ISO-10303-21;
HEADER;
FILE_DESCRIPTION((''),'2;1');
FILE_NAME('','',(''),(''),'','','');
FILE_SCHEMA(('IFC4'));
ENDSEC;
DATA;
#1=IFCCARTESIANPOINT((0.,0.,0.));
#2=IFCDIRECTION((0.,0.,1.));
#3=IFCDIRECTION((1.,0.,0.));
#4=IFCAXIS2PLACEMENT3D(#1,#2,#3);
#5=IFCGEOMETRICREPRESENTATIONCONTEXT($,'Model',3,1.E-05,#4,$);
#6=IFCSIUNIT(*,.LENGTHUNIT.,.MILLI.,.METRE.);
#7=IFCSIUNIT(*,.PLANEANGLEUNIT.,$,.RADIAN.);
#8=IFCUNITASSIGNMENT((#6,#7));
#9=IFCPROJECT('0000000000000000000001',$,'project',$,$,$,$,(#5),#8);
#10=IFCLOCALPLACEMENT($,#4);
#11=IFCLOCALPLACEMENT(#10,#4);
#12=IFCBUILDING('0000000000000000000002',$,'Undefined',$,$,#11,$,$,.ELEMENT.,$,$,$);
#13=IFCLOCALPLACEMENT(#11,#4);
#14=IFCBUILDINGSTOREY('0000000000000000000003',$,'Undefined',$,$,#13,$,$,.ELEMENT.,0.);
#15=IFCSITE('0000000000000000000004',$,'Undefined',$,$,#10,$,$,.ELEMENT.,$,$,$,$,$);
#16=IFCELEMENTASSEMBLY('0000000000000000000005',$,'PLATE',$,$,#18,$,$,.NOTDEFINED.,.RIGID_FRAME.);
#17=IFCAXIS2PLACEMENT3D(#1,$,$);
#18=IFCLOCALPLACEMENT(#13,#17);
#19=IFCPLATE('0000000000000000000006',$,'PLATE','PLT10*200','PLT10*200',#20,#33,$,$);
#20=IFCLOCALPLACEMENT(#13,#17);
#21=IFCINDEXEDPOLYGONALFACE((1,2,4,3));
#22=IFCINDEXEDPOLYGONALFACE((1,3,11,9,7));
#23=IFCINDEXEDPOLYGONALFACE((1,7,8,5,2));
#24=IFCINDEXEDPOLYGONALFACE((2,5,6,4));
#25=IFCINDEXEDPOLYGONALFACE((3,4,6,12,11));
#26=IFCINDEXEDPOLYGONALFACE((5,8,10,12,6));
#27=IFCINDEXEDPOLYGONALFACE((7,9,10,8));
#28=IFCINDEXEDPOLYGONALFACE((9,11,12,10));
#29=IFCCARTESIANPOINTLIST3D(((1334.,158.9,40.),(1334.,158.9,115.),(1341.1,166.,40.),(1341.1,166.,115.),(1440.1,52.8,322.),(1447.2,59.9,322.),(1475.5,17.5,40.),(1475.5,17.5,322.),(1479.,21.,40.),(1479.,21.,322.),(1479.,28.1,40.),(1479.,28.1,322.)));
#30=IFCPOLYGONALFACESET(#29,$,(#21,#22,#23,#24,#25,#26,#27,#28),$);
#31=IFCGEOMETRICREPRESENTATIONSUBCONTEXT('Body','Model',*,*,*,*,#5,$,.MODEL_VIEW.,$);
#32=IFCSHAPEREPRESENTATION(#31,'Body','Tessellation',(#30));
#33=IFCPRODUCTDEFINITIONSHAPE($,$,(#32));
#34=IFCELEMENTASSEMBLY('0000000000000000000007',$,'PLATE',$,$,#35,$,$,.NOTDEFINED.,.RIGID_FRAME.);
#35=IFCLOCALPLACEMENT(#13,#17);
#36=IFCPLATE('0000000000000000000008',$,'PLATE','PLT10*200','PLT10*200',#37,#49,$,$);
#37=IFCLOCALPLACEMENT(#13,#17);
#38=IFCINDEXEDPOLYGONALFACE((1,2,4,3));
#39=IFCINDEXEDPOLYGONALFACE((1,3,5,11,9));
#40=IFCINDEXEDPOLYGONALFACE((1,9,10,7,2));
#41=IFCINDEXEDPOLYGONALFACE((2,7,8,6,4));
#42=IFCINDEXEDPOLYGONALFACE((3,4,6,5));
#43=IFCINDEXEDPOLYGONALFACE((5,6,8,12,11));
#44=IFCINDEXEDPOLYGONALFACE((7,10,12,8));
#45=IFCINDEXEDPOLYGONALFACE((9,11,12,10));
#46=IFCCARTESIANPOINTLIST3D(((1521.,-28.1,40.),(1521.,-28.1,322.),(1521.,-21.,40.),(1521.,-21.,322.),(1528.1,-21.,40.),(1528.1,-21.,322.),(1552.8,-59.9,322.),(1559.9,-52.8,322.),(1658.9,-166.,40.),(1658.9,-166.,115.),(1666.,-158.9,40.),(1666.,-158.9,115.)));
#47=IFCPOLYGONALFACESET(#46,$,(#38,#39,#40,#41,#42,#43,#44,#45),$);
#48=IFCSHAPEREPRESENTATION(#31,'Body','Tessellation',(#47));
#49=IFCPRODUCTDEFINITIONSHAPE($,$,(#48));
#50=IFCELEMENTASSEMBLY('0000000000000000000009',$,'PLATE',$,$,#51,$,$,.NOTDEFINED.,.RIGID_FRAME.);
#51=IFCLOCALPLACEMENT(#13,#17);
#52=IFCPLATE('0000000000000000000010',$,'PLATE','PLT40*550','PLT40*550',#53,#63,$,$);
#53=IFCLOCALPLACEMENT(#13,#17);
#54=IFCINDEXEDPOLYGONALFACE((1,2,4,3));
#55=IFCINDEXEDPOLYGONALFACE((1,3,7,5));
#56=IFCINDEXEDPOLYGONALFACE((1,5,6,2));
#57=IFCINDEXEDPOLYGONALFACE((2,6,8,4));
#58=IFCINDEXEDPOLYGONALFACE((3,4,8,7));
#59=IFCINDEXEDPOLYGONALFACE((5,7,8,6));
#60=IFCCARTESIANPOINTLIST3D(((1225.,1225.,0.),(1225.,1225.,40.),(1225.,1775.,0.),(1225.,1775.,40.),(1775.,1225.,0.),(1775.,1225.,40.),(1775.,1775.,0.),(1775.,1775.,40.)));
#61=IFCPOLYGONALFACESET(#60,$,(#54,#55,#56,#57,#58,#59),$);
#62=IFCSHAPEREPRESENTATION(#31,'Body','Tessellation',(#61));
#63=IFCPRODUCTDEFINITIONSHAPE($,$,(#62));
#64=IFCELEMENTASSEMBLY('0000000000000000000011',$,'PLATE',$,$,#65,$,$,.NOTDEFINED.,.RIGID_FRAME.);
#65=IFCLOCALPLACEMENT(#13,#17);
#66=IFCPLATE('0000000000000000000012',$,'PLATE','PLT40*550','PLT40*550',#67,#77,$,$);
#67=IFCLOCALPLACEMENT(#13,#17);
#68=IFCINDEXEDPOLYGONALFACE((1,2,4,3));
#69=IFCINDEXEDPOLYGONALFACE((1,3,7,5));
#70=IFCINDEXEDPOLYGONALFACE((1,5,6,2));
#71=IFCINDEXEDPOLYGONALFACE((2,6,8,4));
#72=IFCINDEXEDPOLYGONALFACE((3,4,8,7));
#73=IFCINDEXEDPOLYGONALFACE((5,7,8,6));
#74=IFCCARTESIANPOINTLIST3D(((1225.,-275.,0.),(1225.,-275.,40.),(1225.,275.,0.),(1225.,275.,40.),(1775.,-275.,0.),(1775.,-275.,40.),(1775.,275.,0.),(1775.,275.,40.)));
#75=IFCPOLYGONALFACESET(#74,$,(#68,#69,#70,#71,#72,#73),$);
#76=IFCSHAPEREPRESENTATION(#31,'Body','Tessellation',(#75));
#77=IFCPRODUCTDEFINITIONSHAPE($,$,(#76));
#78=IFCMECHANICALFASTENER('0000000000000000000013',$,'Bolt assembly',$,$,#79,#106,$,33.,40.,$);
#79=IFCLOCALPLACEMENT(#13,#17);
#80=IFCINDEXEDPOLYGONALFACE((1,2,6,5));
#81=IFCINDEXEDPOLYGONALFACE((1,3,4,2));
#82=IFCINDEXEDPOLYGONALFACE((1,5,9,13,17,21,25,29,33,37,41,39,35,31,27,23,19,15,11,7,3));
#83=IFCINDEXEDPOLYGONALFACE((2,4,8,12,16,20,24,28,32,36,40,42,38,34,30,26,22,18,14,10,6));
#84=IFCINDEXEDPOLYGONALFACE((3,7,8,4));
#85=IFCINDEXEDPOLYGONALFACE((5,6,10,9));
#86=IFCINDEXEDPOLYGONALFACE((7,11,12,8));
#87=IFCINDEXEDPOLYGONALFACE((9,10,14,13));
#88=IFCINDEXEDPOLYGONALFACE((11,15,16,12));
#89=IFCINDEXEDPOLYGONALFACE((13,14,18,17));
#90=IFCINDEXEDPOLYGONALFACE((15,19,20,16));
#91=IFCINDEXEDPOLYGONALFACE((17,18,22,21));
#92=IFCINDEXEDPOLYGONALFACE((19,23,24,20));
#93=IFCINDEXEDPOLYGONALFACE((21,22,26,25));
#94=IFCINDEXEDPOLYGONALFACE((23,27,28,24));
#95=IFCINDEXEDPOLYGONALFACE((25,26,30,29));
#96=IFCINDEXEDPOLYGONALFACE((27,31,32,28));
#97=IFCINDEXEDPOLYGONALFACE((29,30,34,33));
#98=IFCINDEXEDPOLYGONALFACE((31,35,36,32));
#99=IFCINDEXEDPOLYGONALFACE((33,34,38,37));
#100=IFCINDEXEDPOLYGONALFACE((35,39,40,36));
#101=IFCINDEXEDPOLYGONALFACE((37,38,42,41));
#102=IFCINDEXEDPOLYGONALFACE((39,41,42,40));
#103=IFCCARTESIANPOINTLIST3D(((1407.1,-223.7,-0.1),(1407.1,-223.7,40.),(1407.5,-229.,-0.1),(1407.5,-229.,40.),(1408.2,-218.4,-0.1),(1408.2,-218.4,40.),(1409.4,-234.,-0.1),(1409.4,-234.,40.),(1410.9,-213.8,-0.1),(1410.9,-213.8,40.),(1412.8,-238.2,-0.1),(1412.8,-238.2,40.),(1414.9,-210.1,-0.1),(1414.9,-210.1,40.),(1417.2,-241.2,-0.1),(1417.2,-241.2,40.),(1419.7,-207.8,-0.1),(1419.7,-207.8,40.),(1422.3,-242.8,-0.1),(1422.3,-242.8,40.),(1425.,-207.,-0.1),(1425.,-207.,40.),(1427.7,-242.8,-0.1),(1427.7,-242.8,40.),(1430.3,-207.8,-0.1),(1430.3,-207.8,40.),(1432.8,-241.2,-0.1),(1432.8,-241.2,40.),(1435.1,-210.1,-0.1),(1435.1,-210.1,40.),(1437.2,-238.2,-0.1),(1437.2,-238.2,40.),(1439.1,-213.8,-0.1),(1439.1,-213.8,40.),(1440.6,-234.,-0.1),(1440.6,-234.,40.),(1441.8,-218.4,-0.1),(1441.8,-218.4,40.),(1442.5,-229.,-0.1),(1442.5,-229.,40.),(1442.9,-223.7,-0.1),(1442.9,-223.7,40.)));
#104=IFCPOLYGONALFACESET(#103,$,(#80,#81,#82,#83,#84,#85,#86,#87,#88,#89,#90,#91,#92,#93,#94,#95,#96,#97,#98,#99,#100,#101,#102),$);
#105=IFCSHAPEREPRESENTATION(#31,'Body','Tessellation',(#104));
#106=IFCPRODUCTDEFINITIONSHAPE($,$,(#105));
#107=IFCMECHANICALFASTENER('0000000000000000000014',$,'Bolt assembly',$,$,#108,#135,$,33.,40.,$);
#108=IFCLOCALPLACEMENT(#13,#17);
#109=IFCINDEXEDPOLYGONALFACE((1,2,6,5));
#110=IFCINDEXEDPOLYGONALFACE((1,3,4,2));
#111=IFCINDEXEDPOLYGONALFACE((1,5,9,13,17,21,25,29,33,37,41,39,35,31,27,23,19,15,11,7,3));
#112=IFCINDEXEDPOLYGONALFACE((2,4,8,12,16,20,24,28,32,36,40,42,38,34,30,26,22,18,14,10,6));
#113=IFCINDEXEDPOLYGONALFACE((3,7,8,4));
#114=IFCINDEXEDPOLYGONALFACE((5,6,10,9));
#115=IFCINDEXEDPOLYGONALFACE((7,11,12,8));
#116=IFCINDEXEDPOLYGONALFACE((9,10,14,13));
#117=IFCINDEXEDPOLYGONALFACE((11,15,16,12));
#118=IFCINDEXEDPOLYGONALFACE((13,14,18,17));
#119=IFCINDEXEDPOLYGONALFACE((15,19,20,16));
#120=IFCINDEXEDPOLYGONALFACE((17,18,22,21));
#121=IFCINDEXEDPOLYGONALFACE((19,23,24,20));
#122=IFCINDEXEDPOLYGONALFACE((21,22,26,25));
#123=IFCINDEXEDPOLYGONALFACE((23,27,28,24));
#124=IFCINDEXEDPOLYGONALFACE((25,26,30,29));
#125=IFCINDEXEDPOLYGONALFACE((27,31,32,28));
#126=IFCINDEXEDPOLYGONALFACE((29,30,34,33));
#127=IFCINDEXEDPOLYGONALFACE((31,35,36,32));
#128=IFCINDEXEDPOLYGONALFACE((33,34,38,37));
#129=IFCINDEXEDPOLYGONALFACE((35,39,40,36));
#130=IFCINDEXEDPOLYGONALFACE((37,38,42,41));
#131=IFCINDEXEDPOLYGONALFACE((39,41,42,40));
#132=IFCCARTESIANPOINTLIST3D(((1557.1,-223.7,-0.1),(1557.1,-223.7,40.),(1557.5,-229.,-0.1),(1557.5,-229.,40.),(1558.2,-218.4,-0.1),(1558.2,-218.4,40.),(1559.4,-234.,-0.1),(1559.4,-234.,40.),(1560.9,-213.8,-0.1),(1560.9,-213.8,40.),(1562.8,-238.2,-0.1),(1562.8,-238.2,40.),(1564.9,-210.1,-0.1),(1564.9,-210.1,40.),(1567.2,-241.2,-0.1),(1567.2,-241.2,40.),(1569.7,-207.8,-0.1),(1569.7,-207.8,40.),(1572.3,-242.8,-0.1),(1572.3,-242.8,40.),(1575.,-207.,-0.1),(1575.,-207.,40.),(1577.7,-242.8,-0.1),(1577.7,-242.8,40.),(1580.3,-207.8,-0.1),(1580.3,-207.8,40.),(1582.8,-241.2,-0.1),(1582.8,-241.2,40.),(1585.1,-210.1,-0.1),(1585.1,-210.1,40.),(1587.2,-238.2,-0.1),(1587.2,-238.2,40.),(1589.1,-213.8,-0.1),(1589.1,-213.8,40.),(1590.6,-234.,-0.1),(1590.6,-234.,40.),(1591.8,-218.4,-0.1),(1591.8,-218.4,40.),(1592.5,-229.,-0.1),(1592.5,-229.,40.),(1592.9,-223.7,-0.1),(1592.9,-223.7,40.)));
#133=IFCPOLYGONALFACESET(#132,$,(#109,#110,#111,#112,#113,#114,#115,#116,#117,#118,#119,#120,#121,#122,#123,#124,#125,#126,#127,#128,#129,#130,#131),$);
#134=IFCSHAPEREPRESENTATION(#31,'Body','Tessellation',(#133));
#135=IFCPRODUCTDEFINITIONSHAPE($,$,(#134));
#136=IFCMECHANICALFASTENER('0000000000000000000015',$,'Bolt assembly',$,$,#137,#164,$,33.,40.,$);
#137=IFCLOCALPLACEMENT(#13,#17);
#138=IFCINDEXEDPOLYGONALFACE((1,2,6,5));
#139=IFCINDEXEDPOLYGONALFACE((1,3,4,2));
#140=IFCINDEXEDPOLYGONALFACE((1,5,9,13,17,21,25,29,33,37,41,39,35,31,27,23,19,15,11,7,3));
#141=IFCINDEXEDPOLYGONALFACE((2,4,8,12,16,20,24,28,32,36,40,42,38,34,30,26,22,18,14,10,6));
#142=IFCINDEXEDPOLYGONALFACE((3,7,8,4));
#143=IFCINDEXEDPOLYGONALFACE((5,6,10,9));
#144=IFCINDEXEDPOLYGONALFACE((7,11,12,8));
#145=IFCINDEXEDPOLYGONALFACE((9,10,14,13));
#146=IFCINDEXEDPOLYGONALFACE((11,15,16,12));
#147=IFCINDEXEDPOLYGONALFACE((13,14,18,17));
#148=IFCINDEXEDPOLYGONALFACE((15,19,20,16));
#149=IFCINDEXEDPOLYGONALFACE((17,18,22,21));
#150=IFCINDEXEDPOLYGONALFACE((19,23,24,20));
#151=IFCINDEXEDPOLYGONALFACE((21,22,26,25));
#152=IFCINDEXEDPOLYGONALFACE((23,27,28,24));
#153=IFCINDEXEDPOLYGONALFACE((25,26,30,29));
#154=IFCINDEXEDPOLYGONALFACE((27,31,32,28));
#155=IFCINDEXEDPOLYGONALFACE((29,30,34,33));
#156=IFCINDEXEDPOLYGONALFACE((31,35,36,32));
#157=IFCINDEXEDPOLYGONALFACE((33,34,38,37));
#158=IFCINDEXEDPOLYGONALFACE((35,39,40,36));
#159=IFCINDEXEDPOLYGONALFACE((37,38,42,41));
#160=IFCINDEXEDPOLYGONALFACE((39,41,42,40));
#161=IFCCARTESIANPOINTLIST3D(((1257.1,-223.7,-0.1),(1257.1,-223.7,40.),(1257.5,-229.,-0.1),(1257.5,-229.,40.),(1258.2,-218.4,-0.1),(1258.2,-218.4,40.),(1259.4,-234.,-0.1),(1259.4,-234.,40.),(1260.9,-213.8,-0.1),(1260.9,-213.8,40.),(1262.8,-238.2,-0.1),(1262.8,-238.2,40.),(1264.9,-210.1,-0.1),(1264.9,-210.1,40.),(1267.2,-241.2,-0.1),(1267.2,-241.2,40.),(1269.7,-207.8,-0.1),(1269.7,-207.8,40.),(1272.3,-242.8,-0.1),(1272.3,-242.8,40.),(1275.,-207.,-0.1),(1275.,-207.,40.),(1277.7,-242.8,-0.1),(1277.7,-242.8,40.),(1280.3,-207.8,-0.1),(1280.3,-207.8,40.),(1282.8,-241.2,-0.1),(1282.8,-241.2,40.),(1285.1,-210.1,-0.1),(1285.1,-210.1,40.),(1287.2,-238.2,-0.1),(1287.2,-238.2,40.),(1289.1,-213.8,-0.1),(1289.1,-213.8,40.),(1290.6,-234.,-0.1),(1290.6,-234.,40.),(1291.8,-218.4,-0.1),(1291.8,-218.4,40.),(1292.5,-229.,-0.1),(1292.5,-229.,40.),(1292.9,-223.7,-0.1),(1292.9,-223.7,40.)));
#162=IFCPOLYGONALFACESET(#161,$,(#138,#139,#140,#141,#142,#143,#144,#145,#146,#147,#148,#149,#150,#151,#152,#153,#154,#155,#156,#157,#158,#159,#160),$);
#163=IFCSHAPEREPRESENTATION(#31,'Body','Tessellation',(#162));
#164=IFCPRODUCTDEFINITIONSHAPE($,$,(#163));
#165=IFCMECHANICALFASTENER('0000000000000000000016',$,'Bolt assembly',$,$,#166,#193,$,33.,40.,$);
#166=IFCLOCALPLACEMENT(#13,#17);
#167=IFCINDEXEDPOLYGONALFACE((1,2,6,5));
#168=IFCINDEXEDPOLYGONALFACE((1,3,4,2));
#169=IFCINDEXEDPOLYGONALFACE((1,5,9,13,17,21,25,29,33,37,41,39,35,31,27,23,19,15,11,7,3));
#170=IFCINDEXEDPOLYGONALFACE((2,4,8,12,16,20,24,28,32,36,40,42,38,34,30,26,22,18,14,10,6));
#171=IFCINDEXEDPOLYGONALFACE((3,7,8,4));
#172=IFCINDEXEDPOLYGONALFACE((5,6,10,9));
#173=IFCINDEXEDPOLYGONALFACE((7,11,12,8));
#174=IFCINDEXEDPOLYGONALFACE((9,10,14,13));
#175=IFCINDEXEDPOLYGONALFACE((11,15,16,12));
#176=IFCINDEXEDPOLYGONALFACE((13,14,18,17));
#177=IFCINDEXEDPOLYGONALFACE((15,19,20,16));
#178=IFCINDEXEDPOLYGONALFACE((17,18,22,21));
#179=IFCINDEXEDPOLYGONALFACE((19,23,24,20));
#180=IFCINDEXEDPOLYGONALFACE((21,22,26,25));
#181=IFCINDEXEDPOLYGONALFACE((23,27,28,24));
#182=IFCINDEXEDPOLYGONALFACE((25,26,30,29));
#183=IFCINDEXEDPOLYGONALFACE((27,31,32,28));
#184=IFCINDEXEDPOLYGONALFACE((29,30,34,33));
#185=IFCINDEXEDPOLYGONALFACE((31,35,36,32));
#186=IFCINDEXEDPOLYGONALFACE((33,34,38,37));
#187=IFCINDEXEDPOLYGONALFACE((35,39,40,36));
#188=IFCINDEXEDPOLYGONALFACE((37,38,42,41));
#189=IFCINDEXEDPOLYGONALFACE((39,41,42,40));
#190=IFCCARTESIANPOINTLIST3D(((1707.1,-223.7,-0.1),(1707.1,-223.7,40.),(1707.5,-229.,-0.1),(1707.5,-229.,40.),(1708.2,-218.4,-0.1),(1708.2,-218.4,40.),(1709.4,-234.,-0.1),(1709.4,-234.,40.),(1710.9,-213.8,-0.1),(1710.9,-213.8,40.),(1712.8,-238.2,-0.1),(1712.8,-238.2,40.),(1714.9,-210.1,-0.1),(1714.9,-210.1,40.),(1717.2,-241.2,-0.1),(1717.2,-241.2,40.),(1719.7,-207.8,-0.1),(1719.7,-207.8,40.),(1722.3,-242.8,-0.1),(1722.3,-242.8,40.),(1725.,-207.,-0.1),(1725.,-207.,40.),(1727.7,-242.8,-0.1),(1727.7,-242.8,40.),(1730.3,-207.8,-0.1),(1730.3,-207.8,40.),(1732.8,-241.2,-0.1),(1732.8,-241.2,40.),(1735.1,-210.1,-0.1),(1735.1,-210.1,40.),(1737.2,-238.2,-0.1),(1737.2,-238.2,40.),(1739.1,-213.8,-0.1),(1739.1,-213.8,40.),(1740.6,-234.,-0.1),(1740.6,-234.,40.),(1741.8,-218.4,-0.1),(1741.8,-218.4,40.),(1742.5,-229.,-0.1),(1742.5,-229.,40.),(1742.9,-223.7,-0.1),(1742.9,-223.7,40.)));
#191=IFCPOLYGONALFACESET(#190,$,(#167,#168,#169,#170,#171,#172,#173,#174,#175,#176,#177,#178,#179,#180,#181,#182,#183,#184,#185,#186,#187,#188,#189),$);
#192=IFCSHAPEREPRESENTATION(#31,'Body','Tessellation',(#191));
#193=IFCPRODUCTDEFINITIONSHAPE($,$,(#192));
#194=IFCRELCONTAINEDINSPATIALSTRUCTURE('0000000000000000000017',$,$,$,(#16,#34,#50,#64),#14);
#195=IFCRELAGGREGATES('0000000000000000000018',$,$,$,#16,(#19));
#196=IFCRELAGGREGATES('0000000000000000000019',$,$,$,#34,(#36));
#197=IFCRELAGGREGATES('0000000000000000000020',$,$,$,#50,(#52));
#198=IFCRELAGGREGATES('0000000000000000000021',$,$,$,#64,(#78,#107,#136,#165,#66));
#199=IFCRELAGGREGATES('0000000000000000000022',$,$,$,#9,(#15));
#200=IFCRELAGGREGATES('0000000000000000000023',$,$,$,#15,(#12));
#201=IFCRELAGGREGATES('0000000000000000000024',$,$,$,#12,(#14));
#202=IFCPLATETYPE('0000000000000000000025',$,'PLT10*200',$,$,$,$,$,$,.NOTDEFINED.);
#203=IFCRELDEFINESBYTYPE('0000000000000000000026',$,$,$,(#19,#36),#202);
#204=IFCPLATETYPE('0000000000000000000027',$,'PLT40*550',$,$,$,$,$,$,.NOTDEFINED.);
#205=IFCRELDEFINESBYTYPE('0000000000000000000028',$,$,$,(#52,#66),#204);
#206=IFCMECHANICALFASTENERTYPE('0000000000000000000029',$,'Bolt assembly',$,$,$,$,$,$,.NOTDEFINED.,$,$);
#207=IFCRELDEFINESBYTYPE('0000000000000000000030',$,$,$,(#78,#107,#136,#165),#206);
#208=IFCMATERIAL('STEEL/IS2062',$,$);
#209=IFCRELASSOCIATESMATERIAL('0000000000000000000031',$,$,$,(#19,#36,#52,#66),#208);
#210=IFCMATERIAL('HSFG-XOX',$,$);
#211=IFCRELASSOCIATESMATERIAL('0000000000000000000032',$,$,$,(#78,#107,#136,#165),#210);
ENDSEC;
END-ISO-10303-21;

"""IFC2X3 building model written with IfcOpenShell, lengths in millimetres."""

from ifc_helpers import new_model, si_unit, frame, origin_with_axes, origin_2d_with_axis, place, context, subcontext, project, spatial, polyline, circle, outline, extrude, clip, halfspace, source, transform, mapped, material, type_object, element, aggregate, save


model = new_model("IFC2X3")

# Units and contexts
model_context = context("Model", 3, precision=1e-05, world=origin_with_axes())
body_context = subcontext(model_context, "Body", "Model", "MODEL_VIEW")
ifc_project = project(units=[si_unit("LENGTHUNIT", "METRE", prefix="MILLI"), si_unit("PLANEANGLEUNIT", "RADIAN")], contexts=[model_context])

# Site, building, storey
site_placement = place(None, origin_with_axes())
site = spatial("IfcSite", under=ifc_project, at=site_placement, Name="Undefined", CompositionType="ELEMENT")
building_placement = place(site_placement, origin_with_axes())
building = spatial("IfcBuilding", under=site, at=building_placement, Name="Undefined", CompositionType="ELEMENT")
storey_placement = place(building_placement, origin_with_axes())
storey = spatial("IfcBuildingStorey", under=building, at=storey_placement, Name="Undefined", CompositionType="ELEMENT", Elevation=0.0)

# Shared definitions
ifc_material_1 = material(Name="STEEL/IS2062")

# Element assemblies, plates
assembly_1_placement = place(storey_placement, origin_with_axes())
assembly_1 = element("IfcElementAssembly", 1, at=assembly_1_placement, inside=storey, Name="PLATE", AssemblyPlace="NOTDEFINED", PredefinedType="RIGID_FRAME")
plate_type_1 = type_object("IfcPlateType", Name="PLT10*200", PredefinedType="NOTDEFINED")
plate_1_placement = place(assembly_1_placement, frame((1337.6, 162.4, 322.0), z_axis=(-0.707107, -0.707107, 0.0), x_axis=(0.0, 0.0, -1.0)))
plate_1 = element("IfcPlate", 2, at=plate_1_placement, type_object=plate_type_1, material=ifc_material_1, Name="PLATE", Description="PLT10*200", ObjectType="PLT10*200", context=body_context, shape_type="Clipping", body=[
    clip(extrude(outline(polyline([(0.0, 150.0), (207.0, 0.0), (282.0, 0.0), (282.0, 200.0), (0.0, 200.0), (0.0, 150.0)])), frame((0.0, 0.0, -5.0), z_axis=(0.0, 0.0, 1.0), x_axis=(1.0, 0.0, 0.0)), (0.0, 0.0, 1.0), 10.0), halfspace(frame((282.0, 195.0, -5.0), z_axis=(0.0, 0.707107, -0.707107), x_axis=(0.0, 0.707107, 0.707107)), False)),
])
aggregate(assembly_1, [plate_1])
assembly_2_placement = place(storey_placement, origin_with_axes())
assembly_2 = element("IfcElementAssembly", 3, at=assembly_2_placement, inside=storey, Name="PLATE", AssemblyPlace="NOTDEFINED", PredefinedType="RIGID_FRAME")
plate_2_placement = place(assembly_2_placement, frame((1662.4, -162.4, 322.0), z_axis=(0.707107, 0.707107, 0.0), x_axis=(0.0, 0.0, -1.0)))
plate_2 = element("IfcPlate", 4, at=plate_2_placement, type_object=plate_type_1, material=ifc_material_1, Name="PLATE", Description="PLT10*200", ObjectType="PLT10*200", context=body_context, shape_type="Clipping", body=[
    clip(clip(extrude(outline(polyline([(0.0, 150.0), (207.0, 0.0), (282.0, 0.0), (282.0, 200.0), (0.0, 200.0), (0.0, 150.0)])), frame((0.0, 0.0, -5.0), z_axis=(0.0, 0.0, 1.0), x_axis=(1.0, 0.0, 0.0)), (0.0, 0.0, 1.0), 10.0), halfspace(frame((0.0, -500.0, -700.0), z_axis=(0.0, 0.707107, -0.707107), x_axis=(1.0, 0.0, 0.0)), False)), halfspace(frame((282.0, 195.0, 5.0), z_axis=(0.0, 0.707107, 0.707107), x_axis=(-1.0, 0.0, 0.0)), False)),
])
aggregate(assembly_2, [plate_2])
assembly_3_placement = place(storey_placement, origin_with_axes())
assembly_3 = element("IfcElementAssembly", 5, at=assembly_3_placement, inside=storey, Name="PLATE", AssemblyPlace="NOTDEFINED", PredefinedType="RIGID_FRAME")
plate_type_2 = type_object("IfcPlateType", Name="PLT40*550", PredefinedType="NOTDEFINED")
plate_3_placement = place(assembly_3_placement, frame((1775.0, 1225.0, 20.0), z_axis=(0.0, 0.0, 1.0), x_axis=(0.0, 1.0, 0.0)))
plate_3 = element("IfcPlate", 6, at=plate_3_placement, type_object=plate_type_2, material=ifc_material_1, Name="PLATE", Description="PLT40*550", ObjectType="PLT40*550", context=body_context, shape_type="SweptSolid", body=[
    extrude(outline(polyline([(0.0, 0.0), (550.0, 0.0), (550.0, 550.0), (0.0, 550.0), (0.0, 0.0)])), frame((0.0, 0.0, -20.0), z_axis=(0.0, 0.0, 1.0), x_axis=(1.0, 0.0, 0.0)), (0.0, 0.0, 1.0), 40.0),
])
aggregate(assembly_3, [plate_3])

# Element assembly, plate, mechanical fasteners
assembly_4_placement = place(storey_placement, origin_with_axes())
assembly_4 = element("IfcElementAssembly", 7, at=assembly_4_placement, inside=storey, Name="PLATE", AssemblyPlace="NOTDEFINED", PredefinedType="RIGID_FRAME")
plate_4_placement = place(assembly_4_placement, frame((1775.0, 275.0, 20.0), z_axis=(0.0, 0.0, -1.0), x_axis=(0.0, -1.0, 0.0)))
plate_4 = element("IfcPlate", 8, at=plate_4_placement, type_object=plate_type_2, material=ifc_material_1, Name="PLATE", Description="PLT40*550", ObjectType="PLT40*550", context=body_context, shape_type="SweptSolid", body=[
    extrude(outline(polyline([(0.0, 0.0), (550.0, 0.0), (550.0, 550.0), (0.0, 550.0), (0.0, 0.0)])), frame((0.0, 0.0, -20.0), z_axis=(0.0, 0.0, 1.0), x_axis=(1.0, 0.0, 0.0)), (0.0, 0.0, 1.0), 40.0),
])
ifc_material_2 = material(Name="HSFG-XOX")
mechanical_fastener_type = type_object("IfcMechanicalFastenerType", Name="Bolt assembly")
shared_shape = source(origin_with_axes(), body_context, "Body", "SweptSolid", [
    extrude(circle(Radius=18.0, at=origin_2d_with_axis()), frame((0.0, -40.0, 0.0), z_axis=(0.0, 1.0, 0.0), x_axis=(1.0, 0.0, 0.0)), (0.0, 0.0, 1.0), 40.1),
])
mechanical_fastener_1_placement = place(assembly_4_placement, frame((1425.0, -225.0, 0.0), z_axis=(-1.0, 0.0, 0.0), x_axis=(0.0, 1.0, 0.0)))
mechanical_fastener_1 = element("IfcMechanicalFastener", 9, at=mechanical_fastener_1_placement, type_object=mechanical_fastener_type, material=ifc_material_2, Name="Bolt assembly", NominalDiameter=33.0, NominalLength=40.0, context=body_context, shape_type="MappedRepresentation", body=[
    mapped(shared_shape, transform((0.0, 0.0, 0.0))),
])
mechanical_fastener_2_placement = place(assembly_4_placement, frame((1575.0, -225.0, 0.0), z_axis=(-1.0, 0.0, 0.0), x_axis=(0.0, 1.0, 0.0)))
mechanical_fastener_2 = element("IfcMechanicalFastener", 10, at=mechanical_fastener_2_placement, type_object=mechanical_fastener_type, material=ifc_material_2, Name="Bolt assembly", NominalDiameter=33.0, NominalLength=40.0, context=body_context, shape_type="MappedRepresentation", body=[
    mapped(shared_shape, transform((0.0, 0.0, 0.0))),
])
mechanical_fastener_3_placement = place(assembly_4_placement, frame((1275.0, -225.0, 0.0), z_axis=(-1.0, 0.0, 0.0), x_axis=(0.0, 1.0, 0.0)))
mechanical_fastener_3 = element("IfcMechanicalFastener", 11, at=mechanical_fastener_3_placement, type_object=mechanical_fastener_type, material=ifc_material_2, Name="Bolt assembly", NominalDiameter=33.0, NominalLength=40.0, context=body_context, shape_type="MappedRepresentation", body=[
    mapped(shared_shape, transform((0.0, 0.0, 0.0))),
])
mechanical_fastener_4_placement = place(assembly_4_placement, frame((1725.0, -225.0, 0.0), z_axis=(-1.0, 0.0, 0.0), x_axis=(0.0, 1.0, 0.0)))
mechanical_fastener_4 = element("IfcMechanicalFastener", 12, at=mechanical_fastener_4_placement, type_object=mechanical_fastener_type, material=ifc_material_2, Name="Bolt assembly", NominalDiameter=33.0, NominalLength=40.0, context=body_context, shape_type="MappedRepresentation", body=[
    mapped(shared_shape, transform((0.0, 0.0, 0.0))),
])
aggregate(assembly_4, [mechanical_fastener_1, mechanical_fastener_2, mechanical_fastener_3, mechanical_fastener_4, plate_4])

save(model, "model.ifc")
